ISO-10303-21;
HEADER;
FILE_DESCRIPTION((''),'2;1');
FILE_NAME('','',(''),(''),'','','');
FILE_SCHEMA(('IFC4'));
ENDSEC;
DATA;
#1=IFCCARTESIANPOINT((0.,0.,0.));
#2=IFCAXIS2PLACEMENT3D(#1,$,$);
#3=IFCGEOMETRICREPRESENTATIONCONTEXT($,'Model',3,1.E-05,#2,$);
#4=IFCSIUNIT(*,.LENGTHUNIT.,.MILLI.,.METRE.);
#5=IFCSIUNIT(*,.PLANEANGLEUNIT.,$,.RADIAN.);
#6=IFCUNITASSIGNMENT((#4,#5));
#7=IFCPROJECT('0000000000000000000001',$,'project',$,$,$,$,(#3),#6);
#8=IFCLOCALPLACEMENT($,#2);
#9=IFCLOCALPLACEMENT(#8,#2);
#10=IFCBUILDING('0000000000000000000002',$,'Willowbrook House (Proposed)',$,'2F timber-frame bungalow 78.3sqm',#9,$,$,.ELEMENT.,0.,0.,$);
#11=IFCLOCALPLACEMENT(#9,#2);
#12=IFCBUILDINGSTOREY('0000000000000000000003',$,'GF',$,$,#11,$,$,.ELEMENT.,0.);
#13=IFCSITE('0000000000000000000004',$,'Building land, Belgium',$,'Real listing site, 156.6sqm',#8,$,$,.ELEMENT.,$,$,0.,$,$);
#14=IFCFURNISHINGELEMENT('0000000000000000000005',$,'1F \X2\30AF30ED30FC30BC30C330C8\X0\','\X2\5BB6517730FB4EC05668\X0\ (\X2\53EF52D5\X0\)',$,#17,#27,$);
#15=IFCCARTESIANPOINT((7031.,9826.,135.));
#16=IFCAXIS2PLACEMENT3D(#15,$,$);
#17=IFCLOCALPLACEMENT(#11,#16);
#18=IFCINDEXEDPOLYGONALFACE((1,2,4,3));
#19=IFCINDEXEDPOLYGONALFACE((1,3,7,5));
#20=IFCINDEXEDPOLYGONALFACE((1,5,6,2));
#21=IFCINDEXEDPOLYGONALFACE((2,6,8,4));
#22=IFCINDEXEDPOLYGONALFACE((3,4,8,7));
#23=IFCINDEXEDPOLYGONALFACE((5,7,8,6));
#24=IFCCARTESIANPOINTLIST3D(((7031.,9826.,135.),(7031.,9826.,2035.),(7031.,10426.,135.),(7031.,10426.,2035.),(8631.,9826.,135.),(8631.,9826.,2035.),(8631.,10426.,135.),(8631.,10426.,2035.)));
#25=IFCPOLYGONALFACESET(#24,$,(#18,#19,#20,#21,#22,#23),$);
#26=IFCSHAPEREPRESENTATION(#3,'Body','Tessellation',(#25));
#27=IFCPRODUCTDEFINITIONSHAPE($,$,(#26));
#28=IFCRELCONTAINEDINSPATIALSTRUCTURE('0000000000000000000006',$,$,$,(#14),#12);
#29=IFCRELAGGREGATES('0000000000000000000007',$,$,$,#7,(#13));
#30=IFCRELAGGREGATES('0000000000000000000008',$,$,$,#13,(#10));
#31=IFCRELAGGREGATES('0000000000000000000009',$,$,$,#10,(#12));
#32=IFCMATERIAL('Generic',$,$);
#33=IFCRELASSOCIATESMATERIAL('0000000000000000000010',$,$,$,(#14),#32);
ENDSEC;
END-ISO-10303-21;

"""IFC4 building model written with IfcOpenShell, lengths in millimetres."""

from ifc_helpers import new_model, si_unit, frame, frame_2d, origin, place, context, project, spatial, rectangle, extrude, material, element, save


model = new_model("IFC4")

# Units and contexts
model_context = context("Model", 3, precision=1e-05, world=origin())
ifc_project = project(units=[si_unit("LENGTHUNIT", "METRE", prefix="MILLI"), si_unit("PLANEANGLEUNIT", "RADIAN")], contexts=[model_context])

# Site, building, storey
site_placement = place(None, origin())
site = spatial("IfcSite", under=ifc_project, at=site_placement, Name="Building land, Belgium", ObjectType="Real listing site, 156.6sqm", CompositionType="ELEMENT", RefElevation=0.0)
building_placement = place(site_placement, origin())
building = spatial("IfcBuilding", under=site, at=building_placement, Name="Willowbrook House (Proposed)", ObjectType="2F timber-frame bungalow 78.3sqm", CompositionType="ELEMENT", ElevationOfRefHeight=0.0, ElevationOfTerrain=0.0)
storey_placement = place(building_placement, origin())
storey = spatial("IfcBuildingStorey", under=building, at=storey_placement, Name="GF", CompositionType="ELEMENT", Elevation=0.0)

# Shared definitions
ifc_material_1 = material(Name="Generic")

# Furnishing element
furnishing_placement = place(storey_placement, frame((7031.0, 9826.0, 135.0)))
element("IfcFurnishingElement", 1, at=furnishing_placement, inside=storey, material=ifc_material_1, Name="1F クローゼット", Description="家具・什器 (可動)", context=model_context, shape_type="SweptSolid", body=[
    extrude(rectangle(XDim=1600.0, YDim=600.0, at=frame_2d((800.0, 300.0))), frame((7031.0, 9826.0, 135.0)), (0.0, 0.0, 1.0), 1900.0),
])

save(model, "model.ifc")
